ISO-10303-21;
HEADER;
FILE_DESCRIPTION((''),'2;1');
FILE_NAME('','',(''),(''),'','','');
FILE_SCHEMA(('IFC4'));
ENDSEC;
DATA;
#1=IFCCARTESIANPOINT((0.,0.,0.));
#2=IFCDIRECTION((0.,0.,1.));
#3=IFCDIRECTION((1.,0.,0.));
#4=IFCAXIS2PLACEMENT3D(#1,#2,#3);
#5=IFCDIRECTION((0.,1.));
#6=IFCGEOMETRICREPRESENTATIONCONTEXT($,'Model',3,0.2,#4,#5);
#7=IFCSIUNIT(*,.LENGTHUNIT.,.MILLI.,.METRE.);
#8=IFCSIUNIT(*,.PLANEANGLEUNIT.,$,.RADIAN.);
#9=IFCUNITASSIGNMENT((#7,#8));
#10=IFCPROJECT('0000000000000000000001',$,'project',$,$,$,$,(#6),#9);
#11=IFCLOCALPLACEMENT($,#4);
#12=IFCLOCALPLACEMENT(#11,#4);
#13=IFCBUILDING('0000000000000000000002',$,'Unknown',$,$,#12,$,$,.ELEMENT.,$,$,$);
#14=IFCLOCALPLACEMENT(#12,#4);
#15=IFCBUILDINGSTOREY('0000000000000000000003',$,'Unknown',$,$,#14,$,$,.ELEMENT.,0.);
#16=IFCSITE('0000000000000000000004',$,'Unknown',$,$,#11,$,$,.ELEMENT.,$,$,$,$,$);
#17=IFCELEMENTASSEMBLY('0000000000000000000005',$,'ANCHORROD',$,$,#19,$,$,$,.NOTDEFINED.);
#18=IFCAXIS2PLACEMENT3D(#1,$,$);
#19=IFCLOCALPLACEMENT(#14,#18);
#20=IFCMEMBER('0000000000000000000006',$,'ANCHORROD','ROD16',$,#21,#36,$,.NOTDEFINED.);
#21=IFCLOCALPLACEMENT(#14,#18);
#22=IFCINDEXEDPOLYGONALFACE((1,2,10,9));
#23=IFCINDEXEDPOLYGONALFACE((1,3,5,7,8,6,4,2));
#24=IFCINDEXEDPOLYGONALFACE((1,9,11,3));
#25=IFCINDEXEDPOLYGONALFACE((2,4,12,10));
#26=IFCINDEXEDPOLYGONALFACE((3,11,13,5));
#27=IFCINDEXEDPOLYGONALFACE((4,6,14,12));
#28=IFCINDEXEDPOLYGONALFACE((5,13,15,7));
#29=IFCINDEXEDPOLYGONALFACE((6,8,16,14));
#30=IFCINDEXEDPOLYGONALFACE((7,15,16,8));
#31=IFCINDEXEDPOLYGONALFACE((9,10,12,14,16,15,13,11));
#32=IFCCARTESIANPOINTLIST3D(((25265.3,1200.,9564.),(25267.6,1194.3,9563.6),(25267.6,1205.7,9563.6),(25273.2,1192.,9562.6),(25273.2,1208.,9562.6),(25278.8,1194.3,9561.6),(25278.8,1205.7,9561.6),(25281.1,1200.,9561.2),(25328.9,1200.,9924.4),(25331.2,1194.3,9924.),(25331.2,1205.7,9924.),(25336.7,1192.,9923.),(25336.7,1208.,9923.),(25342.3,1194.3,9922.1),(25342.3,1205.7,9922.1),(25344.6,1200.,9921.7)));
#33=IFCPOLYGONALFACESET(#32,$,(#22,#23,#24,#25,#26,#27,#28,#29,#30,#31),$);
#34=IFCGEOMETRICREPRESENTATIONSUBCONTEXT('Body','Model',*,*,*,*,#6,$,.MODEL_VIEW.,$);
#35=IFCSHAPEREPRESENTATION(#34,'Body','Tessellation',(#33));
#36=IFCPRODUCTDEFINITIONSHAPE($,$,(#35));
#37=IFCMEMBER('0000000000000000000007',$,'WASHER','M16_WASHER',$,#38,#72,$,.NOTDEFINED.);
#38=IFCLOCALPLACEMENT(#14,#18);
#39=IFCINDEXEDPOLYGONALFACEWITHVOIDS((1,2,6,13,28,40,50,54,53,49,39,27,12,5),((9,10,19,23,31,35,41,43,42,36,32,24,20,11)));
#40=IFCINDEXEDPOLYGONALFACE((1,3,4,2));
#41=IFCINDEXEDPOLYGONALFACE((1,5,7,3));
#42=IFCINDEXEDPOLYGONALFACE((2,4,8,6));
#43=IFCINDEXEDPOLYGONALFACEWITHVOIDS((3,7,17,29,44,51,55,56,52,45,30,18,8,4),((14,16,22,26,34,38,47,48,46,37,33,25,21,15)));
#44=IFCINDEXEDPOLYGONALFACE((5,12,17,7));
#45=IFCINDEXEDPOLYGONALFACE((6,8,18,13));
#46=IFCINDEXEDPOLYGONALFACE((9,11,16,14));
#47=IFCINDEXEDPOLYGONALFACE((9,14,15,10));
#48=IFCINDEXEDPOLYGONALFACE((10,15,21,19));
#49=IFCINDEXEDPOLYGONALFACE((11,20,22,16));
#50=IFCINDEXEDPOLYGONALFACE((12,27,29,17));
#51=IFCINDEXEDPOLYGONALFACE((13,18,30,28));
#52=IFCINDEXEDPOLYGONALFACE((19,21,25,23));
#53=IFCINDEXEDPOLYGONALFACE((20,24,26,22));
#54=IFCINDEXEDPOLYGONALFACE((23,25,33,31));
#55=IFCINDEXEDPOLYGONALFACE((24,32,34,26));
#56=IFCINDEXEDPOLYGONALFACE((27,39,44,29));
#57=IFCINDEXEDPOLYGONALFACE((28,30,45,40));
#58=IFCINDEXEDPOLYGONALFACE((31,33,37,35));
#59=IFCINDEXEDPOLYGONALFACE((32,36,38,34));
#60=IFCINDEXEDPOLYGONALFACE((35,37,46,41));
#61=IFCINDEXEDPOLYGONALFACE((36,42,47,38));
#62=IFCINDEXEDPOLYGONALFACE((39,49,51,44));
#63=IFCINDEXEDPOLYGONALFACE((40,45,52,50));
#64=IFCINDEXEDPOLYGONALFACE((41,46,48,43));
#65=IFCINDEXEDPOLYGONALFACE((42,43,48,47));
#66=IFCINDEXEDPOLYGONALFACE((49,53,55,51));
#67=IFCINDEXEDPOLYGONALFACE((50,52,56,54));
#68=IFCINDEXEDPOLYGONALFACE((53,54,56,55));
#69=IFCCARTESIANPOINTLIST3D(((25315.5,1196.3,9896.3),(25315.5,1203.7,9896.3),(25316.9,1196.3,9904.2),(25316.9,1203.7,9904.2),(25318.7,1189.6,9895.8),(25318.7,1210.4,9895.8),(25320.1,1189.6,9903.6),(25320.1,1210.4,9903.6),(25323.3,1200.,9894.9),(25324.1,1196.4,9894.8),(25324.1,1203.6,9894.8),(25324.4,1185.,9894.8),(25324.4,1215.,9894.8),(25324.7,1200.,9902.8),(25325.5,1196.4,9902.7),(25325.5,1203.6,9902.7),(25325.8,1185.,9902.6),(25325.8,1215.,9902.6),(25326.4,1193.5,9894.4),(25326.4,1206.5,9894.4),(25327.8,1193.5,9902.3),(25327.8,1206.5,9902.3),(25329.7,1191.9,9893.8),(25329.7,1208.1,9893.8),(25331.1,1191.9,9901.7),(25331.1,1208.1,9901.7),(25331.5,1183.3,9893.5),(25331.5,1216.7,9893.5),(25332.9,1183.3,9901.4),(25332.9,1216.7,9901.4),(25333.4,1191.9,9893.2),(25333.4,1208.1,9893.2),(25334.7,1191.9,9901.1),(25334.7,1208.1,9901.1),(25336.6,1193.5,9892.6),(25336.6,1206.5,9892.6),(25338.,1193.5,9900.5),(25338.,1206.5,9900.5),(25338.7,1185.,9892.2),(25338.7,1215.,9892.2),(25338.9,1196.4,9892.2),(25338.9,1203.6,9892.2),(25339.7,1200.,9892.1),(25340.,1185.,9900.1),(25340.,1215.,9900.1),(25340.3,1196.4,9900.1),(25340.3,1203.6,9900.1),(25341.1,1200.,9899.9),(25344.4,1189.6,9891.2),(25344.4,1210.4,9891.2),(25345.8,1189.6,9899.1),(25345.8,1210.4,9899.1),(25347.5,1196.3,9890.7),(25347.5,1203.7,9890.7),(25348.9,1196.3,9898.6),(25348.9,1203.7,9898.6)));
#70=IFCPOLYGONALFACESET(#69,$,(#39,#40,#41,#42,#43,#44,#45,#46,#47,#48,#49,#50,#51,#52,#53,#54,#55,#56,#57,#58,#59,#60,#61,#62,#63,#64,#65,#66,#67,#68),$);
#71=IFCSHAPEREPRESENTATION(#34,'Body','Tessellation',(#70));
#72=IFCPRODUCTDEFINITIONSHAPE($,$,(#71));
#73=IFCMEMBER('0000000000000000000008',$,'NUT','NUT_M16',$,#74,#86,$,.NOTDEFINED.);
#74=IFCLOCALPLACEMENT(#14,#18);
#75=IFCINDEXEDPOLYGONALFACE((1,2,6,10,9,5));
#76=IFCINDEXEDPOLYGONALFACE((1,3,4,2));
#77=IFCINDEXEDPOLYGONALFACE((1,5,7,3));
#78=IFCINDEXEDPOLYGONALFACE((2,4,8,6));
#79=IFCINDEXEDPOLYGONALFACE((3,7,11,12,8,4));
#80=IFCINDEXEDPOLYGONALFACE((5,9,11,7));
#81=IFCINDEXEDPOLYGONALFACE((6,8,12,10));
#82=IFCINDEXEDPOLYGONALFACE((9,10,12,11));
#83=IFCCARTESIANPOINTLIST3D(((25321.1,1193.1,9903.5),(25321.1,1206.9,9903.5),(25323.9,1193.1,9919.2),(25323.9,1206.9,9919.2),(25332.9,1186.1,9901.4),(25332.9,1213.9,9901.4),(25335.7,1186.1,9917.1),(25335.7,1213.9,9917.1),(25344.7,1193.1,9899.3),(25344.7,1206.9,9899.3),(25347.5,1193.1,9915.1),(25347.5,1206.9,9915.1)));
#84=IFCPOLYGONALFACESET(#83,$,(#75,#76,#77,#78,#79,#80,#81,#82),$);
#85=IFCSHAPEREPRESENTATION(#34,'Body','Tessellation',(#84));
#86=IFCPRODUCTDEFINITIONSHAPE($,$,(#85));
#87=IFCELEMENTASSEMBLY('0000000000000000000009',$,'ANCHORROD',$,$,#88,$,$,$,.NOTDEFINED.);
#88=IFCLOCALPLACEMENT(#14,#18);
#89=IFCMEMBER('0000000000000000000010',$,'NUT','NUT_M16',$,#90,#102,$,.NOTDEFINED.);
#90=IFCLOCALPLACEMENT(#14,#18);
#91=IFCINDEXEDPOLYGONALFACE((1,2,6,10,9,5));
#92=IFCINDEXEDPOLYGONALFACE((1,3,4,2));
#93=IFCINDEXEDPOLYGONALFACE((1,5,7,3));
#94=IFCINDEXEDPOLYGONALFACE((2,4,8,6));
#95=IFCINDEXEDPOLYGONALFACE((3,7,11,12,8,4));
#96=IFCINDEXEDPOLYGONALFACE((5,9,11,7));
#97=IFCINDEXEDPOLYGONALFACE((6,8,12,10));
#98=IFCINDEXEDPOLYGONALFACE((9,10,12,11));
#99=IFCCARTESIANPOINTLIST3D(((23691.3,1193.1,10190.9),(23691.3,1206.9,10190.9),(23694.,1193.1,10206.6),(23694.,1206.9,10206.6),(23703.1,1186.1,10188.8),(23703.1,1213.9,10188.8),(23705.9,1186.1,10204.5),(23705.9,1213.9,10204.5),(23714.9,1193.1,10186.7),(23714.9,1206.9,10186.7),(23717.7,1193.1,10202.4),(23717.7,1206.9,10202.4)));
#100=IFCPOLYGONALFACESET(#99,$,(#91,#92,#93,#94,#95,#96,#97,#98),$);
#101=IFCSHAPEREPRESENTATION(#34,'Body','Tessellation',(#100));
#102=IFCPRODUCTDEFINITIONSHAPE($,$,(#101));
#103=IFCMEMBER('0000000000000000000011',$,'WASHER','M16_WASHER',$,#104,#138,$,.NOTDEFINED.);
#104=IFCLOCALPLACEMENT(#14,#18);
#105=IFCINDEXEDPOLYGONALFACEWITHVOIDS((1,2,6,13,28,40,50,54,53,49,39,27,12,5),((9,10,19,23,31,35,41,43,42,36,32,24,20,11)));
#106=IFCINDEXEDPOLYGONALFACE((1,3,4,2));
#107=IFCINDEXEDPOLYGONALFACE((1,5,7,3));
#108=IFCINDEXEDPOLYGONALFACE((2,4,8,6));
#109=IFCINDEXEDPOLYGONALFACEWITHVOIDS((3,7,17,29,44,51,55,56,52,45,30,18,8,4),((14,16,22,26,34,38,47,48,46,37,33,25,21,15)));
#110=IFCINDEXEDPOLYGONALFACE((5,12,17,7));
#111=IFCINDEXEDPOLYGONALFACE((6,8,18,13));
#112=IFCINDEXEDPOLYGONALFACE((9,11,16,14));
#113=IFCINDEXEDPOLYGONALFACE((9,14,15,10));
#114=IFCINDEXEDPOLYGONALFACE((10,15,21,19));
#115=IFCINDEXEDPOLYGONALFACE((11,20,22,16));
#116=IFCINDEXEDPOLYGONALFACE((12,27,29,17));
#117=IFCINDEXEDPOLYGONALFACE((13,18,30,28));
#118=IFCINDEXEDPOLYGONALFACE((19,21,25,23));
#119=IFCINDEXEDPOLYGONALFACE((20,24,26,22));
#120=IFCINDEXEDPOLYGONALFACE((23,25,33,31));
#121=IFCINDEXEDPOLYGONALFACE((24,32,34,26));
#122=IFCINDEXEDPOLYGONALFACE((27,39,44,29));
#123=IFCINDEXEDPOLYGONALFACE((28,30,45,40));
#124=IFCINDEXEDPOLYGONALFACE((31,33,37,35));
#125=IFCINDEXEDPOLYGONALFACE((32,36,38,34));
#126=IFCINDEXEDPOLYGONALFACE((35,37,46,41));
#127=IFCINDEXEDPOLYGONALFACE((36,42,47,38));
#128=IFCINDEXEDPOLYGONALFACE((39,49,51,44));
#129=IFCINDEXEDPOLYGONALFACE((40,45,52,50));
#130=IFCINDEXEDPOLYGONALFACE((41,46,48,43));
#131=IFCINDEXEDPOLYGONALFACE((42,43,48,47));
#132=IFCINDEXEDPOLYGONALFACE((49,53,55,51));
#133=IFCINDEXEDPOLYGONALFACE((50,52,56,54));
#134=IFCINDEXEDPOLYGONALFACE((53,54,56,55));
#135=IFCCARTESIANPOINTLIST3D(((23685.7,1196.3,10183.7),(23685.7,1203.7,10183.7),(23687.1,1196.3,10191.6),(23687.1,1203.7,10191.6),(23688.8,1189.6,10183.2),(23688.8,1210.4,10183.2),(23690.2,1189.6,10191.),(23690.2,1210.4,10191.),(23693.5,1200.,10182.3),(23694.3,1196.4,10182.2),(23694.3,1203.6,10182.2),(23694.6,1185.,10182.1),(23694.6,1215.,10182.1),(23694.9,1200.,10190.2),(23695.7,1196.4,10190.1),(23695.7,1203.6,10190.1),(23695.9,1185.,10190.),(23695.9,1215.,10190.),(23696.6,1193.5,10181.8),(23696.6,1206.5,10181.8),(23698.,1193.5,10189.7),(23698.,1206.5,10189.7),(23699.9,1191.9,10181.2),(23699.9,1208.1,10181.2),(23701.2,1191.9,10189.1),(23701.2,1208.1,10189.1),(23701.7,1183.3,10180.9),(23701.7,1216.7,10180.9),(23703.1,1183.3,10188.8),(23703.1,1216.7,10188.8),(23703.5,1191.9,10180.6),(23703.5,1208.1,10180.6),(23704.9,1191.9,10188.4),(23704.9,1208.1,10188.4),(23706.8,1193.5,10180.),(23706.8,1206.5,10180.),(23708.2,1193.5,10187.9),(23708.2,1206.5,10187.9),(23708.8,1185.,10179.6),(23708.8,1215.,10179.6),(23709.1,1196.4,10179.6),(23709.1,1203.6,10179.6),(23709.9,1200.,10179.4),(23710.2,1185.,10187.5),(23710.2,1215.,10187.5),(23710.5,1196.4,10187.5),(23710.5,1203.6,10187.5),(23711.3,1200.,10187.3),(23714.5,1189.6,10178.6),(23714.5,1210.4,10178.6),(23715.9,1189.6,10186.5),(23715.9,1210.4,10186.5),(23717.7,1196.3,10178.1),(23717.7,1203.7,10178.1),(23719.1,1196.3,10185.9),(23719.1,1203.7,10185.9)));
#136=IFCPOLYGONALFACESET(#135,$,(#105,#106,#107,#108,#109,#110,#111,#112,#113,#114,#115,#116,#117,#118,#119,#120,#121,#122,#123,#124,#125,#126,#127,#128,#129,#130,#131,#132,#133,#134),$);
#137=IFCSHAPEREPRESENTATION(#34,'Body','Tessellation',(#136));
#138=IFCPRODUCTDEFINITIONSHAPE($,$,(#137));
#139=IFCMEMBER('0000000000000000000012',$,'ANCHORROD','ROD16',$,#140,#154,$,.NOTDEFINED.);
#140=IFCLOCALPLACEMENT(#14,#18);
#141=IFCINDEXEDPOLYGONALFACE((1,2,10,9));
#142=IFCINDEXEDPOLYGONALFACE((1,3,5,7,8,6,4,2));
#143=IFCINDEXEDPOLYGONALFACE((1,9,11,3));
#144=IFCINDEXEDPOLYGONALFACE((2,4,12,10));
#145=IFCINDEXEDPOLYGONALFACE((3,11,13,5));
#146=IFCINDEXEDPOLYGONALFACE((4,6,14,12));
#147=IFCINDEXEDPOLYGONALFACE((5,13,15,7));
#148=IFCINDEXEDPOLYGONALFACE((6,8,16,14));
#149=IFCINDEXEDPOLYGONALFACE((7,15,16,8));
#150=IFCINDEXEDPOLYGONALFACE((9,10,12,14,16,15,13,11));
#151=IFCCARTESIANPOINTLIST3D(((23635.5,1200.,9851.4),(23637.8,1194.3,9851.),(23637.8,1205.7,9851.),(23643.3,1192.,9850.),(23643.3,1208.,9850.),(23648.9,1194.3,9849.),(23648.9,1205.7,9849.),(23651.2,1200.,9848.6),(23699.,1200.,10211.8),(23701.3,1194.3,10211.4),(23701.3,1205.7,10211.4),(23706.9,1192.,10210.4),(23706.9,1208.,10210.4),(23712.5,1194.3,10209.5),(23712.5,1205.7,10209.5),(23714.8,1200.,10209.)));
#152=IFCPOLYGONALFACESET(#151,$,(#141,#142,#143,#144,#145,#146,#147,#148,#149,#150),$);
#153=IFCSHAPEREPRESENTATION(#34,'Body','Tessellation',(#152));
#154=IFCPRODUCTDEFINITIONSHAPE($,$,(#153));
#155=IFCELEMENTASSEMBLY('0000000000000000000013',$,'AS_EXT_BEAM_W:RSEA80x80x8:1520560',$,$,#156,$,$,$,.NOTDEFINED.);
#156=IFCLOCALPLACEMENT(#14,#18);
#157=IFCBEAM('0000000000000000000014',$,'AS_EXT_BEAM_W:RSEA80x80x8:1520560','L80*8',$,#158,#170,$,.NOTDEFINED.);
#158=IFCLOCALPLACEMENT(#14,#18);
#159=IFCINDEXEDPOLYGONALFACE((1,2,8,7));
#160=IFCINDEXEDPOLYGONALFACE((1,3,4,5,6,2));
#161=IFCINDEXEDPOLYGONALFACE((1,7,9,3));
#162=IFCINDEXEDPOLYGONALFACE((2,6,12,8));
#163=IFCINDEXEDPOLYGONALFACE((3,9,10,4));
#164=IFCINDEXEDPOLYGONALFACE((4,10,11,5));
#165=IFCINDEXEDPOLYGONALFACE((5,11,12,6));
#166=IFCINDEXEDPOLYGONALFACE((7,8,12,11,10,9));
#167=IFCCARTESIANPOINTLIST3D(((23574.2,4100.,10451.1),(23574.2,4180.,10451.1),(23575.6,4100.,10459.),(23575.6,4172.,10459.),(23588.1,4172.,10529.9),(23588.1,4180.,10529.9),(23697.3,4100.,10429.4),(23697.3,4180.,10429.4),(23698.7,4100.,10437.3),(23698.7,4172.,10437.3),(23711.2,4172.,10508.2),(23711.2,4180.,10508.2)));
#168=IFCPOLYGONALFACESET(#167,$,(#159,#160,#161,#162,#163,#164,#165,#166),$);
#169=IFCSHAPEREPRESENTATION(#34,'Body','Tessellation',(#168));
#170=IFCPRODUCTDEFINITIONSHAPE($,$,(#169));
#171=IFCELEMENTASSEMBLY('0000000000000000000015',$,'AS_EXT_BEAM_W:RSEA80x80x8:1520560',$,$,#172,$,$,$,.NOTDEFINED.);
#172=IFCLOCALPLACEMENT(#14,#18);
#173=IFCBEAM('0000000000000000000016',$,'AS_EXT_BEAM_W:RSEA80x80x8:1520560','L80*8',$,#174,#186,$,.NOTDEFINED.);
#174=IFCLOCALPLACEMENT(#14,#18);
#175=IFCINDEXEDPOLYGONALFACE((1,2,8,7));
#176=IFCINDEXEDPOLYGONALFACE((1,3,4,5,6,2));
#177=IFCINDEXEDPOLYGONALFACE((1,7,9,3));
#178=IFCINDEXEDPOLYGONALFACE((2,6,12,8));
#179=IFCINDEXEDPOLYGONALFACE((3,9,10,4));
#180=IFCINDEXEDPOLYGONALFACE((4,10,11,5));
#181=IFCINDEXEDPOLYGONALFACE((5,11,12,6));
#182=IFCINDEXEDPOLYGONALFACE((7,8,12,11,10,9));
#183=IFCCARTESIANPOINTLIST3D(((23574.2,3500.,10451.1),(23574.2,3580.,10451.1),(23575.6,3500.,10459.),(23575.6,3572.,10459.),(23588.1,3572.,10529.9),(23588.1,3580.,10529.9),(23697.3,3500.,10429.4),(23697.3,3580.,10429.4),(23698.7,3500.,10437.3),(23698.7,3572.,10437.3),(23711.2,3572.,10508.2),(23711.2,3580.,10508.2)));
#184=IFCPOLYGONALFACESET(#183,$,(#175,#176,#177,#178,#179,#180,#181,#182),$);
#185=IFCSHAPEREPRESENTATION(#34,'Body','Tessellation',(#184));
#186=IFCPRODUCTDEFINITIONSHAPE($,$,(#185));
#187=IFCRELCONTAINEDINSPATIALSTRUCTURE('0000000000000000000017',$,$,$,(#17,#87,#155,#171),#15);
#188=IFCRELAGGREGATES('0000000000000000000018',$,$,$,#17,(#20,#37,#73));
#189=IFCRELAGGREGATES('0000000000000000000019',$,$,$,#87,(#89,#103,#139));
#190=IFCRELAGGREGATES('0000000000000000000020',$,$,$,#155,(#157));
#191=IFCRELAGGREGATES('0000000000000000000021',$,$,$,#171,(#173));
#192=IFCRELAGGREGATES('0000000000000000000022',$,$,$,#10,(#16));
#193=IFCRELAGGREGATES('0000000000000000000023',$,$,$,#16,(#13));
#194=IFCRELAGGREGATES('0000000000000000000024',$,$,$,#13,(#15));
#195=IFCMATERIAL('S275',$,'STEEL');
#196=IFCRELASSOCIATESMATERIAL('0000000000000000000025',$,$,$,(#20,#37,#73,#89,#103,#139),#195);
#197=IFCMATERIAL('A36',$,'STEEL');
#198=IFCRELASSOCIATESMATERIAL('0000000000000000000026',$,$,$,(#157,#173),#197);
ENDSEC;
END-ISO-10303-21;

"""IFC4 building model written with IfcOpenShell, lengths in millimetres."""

from ifc_helpers import new_model, si_unit, direction, frame, origin_with_axes, place, context, subcontext, project, spatial, line, indexed_curve, outline, extrude, material, element, aggregate, save


model = new_model("IFC4")

# Units and contexts
model_context = context("Model", 3, precision=0.2, world=origin_with_axes(), true_north=direction((0.0, 1.0)))
body_context = subcontext(model_context, "Body", "Model", "MODEL_VIEW")
ifc_project = project(units=[si_unit("LENGTHUNIT", "METRE", prefix="MILLI"), si_unit("PLANEANGLEUNIT", "RADIAN")], contexts=[model_context])

# Site, building, storey
site_placement = place(None, origin_with_axes())
site = spatial("IfcSite", under=ifc_project, at=site_placement, Name="Unknown", CompositionType="ELEMENT")
building_placement = place(site_placement, origin_with_axes())
building = spatial("IfcBuilding", under=site, at=building_placement, Name="Unknown", CompositionType="ELEMENT")
storey_placement = place(building_placement, origin_with_axes())
storey = spatial("IfcBuildingStorey", under=building, at=storey_placement, Name="Unknown", CompositionType="ELEMENT", Elevation=0.0)

# Element assemblies, members
assembly_1_placement = place(storey_placement, frame((25336.7, 1200.0, 9923.0), z_axis=(0.0, -1.0, 0.0), x_axis=(-0.173648, 0.0, -0.984808)))
assembly_1 = element("IfcElementAssembly", 1, at=assembly_1_placement, inside=storey, Name="ANCHORROD", PredefinedType="NOTDEFINED")
ifc_material_1 = material(Name="S275", Category="STEEL")
member_1_placement = place(assembly_1_placement, origin_with_axes())
member_1 = element("IfcMember", 2, at=member_1_placement, material=ifc_material_1, Name="ANCHORROD", Description="ROD16", PredefinedType="NOTDEFINED", context=body_context, shape_type="SolidModel", body=[
    extrude(outline(indexed_curve([(8.0, 0.0), (5.7, 5.7), (0.0, 8.0), (-5.7, 5.7), (-8.0, 0.0), (-5.7, -5.7), (0.0, -8.0), (5.7, -5.7)], segments=[line(1, 2, 3, 4, 5, 6, 7, 8, 1)])), frame((0.0, 0.0, 0.0), z_axis=(-1.0, 0.0, 0.0), x_axis=(0.0, 0.0, 1.0)), (0.0, 0.0, -1.0), 366.0),
])
member_2_placement = place(assembly_1_placement, frame((22.0, 0.0, 0.0), z_axis=(0.0, 0.0, 1.0), x_axis=(1.0, 0.0, 0.0)))
member_2 = element("IfcMember", 3, at=member_2_placement, material=ifc_material_1, Name="WASHER", Description="M16_WASHER", PredefinedType="NOTDEFINED", context=body_context, shape_type="SolidModel", body=[
    extrude(outline(indexed_curve([(16.7, 0.0), (15.0, 7.2), (10.4, 13.0), (3.7, 16.3), (-3.7, 16.3), (-10.4, 13.0), (-15.0, 7.2), (-16.7, 0.0), (-15.0, -7.2), (-10.4, -13.0), (-3.7, -16.3), (3.7, -16.3), (10.4, -13.0), (15.0, -7.2)], segments=[line(1, 2, 3, 4, 5, 6, 7, 8, 9, 10, 11, 12, 13, 14, 1)]), holes=[indexed_curve([(0.0, 8.3), (3.6, 7.5), (6.5, 5.2), (8.1, 1.9), (8.1, -1.9), (6.5, -5.2), (3.6, -7.5), (0.0, -8.3), (-3.6, -7.5), (-6.5, -5.2), (-8.1, -1.9), (-8.1, 1.9), (-6.5, 5.2), (-3.6, 7.5)], segments=[line(1, 2, 3, 4, 5, 6, 7, 8, 9, 10, 11, 12, 13, 14, 1)])]), frame((0.0, 0.0, 0.0), z_axis=(-1.0, 0.0, 0.0), x_axis=(0.0, 0.0, 1.0)), (0.0, 0.0, -1.0), 8.0),
])
member_3_placement = place(assembly_1_placement, frame((6.0, 0.0, 0.0), z_axis=(0.0, 0.0, 1.0), x_axis=(1.0, 0.0, 0.0)))
member_3 = element("IfcMember", 4, at=member_3_placement, material=ifc_material_1, Name="NUT", Description="NUT_M16", PredefinedType="NOTDEFINED", context=body_context, shape_type="SolidModel", body=[
    extrude(outline(indexed_curve([(6.9, -12.0), (13.9, 0.0), (6.9, 12.0), (-6.9, 12.0), (-13.9, 0.0), (-6.9, -12.0)], segments=[line(1, 2, 3, 4, 5, 6, 1)])), frame((0.0, 0.0, 0.0), z_axis=(-1.0, 0.0, 0.0), x_axis=(0.0, 0.0, 1.0)), (0.0, 0.0, -1.0), 16.0),
])
aggregate(assembly_1, [member_1, member_2, member_3])
assembly_2_placement = place(storey_placement, frame((23706.9, 1200.0, 10210.4), z_axis=(0.0, -1.0, 0.0), x_axis=(-0.173648, 0.0, -0.984808)))
assembly_2 = element("IfcElementAssembly", 5, at=assembly_2_placement, inside=storey, Name="ANCHORROD", PredefinedType="NOTDEFINED")
member_4_placement = place(assembly_2_placement, frame((6.0, 0.0, 0.0), z_axis=(0.0, 0.0, 1.0), x_axis=(1.0, 0.0, 0.0)))
member_4 = element("IfcMember", 6, at=member_4_placement, material=ifc_material_1, Name="NUT", Description="NUT_M16", PredefinedType="NOTDEFINED", context=body_context, shape_type="SolidModel", body=[
    extrude(outline(indexed_curve([(6.9, -12.0), (13.9, 0.0), (6.9, 12.0), (-6.9, 12.0), (-13.9, 0.0), (-6.9, -12.0)], segments=[line(1, 2, 3, 4, 5, 6, 1)])), frame((0.0, 0.0, 0.0), z_axis=(-1.0, 0.0, 0.0), x_axis=(0.0, 0.0, 1.0)), (0.0, 0.0, -1.0), 16.0),
])
member_5_placement = place(assembly_2_placement, frame((22.0, 0.0, 0.0), z_axis=(0.0, 0.0, 1.0), x_axis=(1.0, 0.0, 0.0)))
member_5 = element("IfcMember", 7, at=member_5_placement, material=ifc_material_1, Name="WASHER", Description="M16_WASHER", PredefinedType="NOTDEFINED", context=body_context, shape_type="SolidModel", body=[
    extrude(outline(indexed_curve([(16.7, 0.0), (15.0, 7.2), (10.4, 13.0), (3.7, 16.3), (-3.7, 16.3), (-10.4, 13.0), (-15.0, 7.2), (-16.7, 0.0), (-15.0, -7.2), (-10.4, -13.0), (-3.7, -16.3), (3.7, -16.3), (10.4, -13.0), (15.0, -7.2)], segments=[line(1, 2, 3, 4, 5, 6, 7, 8, 9, 10, 11, 12, 13, 14, 1)]), holes=[indexed_curve([(0.0, 8.3), (3.6, 7.5), (6.5, 5.2), (8.1, 1.9), (8.1, -1.9), (6.5, -5.2), (3.6, -7.5), (0.0, -8.3), (-3.6, -7.5), (-6.5, -5.2), (-8.1, -1.9), (-8.1, 1.9), (-6.5, 5.2), (-3.6, 7.5)], segments=[line(1, 2, 3, 4, 5, 6, 7, 8, 9, 10, 11, 12, 13, 14, 1)])]), frame((0.0, 0.0, 0.0), z_axis=(-1.0, 0.0, 0.0), x_axis=(0.0, 0.0, 1.0)), (0.0, 0.0, -1.0), 8.0),
])
member_6_placement = place(assembly_2_placement, origin_with_axes())
member_6 = element("IfcMember", 8, at=member_6_placement, material=ifc_material_1, Name="ANCHORROD", Description="ROD16", PredefinedType="NOTDEFINED", context=body_context, shape_type="SolidModel", body=[
    extrude(outline(indexed_curve([(8.0, 0.0), (5.7, 5.7), (0.0, 8.0), (-5.7, 5.7), (-8.0, 0.0), (-5.7, -5.7), (0.0, -8.0), (5.7, -5.7)], segments=[line(1, 2, 3, 4, 5, 6, 7, 8, 1)])), frame((0.0, 0.0, 0.0), z_axis=(-1.0, 0.0, 0.0), x_axis=(0.0, 0.0, 1.0)), (0.0, 0.0, -1.0), 366.0),
])
aggregate(assembly_2, [member_4, member_5, member_6])

# Element assemblies, beams
assembly_3_placement = place(storey_placement, frame((23581.1, 4140.0, 10490.5), z_axis=(0.0, -1.0, 0.0), x_axis=(0.984808, 0.0, -0.173648)))
assembly_3 = element("IfcElementAssembly", 9, at=assembly_3_placement, inside=storey, Name="AS_EXT_BEAM_W:RSEA80x80x8:1520560", PredefinedType="NOTDEFINED")
ifc_material_2 = material(Name="A36", Category="STEEL")
beam_1_placement = place(assembly_3_placement, origin_with_axes())
beam_1 = element("IfcBeam", 10, at=beam_1_placement, material=ifc_material_2, Name="AS_EXT_BEAM_W:RSEA80x80x8:1520560", Description="L80*8", PredefinedType="NOTDEFINED", context=body_context, shape_type="SolidModel", body=[
    extrude(outline(indexed_curve([(-40.0, -40.0), (40.0, -40.0), (40.0, -32.0), (-32.0, -32.0), (-32.0, 40.0), (-40.0, 40.0)], segments=[line(1, 2, 3, 4, 5, 6, 1)])), frame((0.0, 0.0, 0.0), z_axis=(-1.0, 0.0, 0.0), x_axis=(0.0, 0.0, 1.0)), (0.0, 0.0, -1.0), 125.0),
])
assembly_4_placement = place(storey_placement, frame((23581.1, 3540.0, 10490.5), z_axis=(0.0, -1.0, 0.0), x_axis=(0.984808, 0.0, -0.173648)))
assembly_4 = element("IfcElementAssembly", 11, at=assembly_4_placement, inside=storey, Name="AS_EXT_BEAM_W:RSEA80x80x8:1520560", PredefinedType="NOTDEFINED")
beam_2_placement = place(assembly_4_placement, origin_with_axes())
beam_2 = element("IfcBeam", 12, at=beam_2_placement, material=ifc_material_2, Name="AS_EXT_BEAM_W:RSEA80x80x8:1520560", Description="L80*8", PredefinedType="NOTDEFINED", context=body_context, shape_type="SolidModel", body=[
    extrude(outline(indexed_curve([(-40.0, -40.0), (40.0, -40.0), (40.0, -32.0), (-32.0, -32.0), (-32.0, 40.0), (-40.0, 40.0)], segments=[line(1, 2, 3, 4, 5, 6, 1)])), frame((0.0, 0.0, 0.0), z_axis=(-1.0, 0.0, 0.0), x_axis=(0.0, 0.0, 1.0)), (0.0, 0.0, -1.0), 125.0),
])

aggregate(assembly_3, [beam_1])
aggregate(assembly_4, [beam_2])

save(model, "model.ifc")
